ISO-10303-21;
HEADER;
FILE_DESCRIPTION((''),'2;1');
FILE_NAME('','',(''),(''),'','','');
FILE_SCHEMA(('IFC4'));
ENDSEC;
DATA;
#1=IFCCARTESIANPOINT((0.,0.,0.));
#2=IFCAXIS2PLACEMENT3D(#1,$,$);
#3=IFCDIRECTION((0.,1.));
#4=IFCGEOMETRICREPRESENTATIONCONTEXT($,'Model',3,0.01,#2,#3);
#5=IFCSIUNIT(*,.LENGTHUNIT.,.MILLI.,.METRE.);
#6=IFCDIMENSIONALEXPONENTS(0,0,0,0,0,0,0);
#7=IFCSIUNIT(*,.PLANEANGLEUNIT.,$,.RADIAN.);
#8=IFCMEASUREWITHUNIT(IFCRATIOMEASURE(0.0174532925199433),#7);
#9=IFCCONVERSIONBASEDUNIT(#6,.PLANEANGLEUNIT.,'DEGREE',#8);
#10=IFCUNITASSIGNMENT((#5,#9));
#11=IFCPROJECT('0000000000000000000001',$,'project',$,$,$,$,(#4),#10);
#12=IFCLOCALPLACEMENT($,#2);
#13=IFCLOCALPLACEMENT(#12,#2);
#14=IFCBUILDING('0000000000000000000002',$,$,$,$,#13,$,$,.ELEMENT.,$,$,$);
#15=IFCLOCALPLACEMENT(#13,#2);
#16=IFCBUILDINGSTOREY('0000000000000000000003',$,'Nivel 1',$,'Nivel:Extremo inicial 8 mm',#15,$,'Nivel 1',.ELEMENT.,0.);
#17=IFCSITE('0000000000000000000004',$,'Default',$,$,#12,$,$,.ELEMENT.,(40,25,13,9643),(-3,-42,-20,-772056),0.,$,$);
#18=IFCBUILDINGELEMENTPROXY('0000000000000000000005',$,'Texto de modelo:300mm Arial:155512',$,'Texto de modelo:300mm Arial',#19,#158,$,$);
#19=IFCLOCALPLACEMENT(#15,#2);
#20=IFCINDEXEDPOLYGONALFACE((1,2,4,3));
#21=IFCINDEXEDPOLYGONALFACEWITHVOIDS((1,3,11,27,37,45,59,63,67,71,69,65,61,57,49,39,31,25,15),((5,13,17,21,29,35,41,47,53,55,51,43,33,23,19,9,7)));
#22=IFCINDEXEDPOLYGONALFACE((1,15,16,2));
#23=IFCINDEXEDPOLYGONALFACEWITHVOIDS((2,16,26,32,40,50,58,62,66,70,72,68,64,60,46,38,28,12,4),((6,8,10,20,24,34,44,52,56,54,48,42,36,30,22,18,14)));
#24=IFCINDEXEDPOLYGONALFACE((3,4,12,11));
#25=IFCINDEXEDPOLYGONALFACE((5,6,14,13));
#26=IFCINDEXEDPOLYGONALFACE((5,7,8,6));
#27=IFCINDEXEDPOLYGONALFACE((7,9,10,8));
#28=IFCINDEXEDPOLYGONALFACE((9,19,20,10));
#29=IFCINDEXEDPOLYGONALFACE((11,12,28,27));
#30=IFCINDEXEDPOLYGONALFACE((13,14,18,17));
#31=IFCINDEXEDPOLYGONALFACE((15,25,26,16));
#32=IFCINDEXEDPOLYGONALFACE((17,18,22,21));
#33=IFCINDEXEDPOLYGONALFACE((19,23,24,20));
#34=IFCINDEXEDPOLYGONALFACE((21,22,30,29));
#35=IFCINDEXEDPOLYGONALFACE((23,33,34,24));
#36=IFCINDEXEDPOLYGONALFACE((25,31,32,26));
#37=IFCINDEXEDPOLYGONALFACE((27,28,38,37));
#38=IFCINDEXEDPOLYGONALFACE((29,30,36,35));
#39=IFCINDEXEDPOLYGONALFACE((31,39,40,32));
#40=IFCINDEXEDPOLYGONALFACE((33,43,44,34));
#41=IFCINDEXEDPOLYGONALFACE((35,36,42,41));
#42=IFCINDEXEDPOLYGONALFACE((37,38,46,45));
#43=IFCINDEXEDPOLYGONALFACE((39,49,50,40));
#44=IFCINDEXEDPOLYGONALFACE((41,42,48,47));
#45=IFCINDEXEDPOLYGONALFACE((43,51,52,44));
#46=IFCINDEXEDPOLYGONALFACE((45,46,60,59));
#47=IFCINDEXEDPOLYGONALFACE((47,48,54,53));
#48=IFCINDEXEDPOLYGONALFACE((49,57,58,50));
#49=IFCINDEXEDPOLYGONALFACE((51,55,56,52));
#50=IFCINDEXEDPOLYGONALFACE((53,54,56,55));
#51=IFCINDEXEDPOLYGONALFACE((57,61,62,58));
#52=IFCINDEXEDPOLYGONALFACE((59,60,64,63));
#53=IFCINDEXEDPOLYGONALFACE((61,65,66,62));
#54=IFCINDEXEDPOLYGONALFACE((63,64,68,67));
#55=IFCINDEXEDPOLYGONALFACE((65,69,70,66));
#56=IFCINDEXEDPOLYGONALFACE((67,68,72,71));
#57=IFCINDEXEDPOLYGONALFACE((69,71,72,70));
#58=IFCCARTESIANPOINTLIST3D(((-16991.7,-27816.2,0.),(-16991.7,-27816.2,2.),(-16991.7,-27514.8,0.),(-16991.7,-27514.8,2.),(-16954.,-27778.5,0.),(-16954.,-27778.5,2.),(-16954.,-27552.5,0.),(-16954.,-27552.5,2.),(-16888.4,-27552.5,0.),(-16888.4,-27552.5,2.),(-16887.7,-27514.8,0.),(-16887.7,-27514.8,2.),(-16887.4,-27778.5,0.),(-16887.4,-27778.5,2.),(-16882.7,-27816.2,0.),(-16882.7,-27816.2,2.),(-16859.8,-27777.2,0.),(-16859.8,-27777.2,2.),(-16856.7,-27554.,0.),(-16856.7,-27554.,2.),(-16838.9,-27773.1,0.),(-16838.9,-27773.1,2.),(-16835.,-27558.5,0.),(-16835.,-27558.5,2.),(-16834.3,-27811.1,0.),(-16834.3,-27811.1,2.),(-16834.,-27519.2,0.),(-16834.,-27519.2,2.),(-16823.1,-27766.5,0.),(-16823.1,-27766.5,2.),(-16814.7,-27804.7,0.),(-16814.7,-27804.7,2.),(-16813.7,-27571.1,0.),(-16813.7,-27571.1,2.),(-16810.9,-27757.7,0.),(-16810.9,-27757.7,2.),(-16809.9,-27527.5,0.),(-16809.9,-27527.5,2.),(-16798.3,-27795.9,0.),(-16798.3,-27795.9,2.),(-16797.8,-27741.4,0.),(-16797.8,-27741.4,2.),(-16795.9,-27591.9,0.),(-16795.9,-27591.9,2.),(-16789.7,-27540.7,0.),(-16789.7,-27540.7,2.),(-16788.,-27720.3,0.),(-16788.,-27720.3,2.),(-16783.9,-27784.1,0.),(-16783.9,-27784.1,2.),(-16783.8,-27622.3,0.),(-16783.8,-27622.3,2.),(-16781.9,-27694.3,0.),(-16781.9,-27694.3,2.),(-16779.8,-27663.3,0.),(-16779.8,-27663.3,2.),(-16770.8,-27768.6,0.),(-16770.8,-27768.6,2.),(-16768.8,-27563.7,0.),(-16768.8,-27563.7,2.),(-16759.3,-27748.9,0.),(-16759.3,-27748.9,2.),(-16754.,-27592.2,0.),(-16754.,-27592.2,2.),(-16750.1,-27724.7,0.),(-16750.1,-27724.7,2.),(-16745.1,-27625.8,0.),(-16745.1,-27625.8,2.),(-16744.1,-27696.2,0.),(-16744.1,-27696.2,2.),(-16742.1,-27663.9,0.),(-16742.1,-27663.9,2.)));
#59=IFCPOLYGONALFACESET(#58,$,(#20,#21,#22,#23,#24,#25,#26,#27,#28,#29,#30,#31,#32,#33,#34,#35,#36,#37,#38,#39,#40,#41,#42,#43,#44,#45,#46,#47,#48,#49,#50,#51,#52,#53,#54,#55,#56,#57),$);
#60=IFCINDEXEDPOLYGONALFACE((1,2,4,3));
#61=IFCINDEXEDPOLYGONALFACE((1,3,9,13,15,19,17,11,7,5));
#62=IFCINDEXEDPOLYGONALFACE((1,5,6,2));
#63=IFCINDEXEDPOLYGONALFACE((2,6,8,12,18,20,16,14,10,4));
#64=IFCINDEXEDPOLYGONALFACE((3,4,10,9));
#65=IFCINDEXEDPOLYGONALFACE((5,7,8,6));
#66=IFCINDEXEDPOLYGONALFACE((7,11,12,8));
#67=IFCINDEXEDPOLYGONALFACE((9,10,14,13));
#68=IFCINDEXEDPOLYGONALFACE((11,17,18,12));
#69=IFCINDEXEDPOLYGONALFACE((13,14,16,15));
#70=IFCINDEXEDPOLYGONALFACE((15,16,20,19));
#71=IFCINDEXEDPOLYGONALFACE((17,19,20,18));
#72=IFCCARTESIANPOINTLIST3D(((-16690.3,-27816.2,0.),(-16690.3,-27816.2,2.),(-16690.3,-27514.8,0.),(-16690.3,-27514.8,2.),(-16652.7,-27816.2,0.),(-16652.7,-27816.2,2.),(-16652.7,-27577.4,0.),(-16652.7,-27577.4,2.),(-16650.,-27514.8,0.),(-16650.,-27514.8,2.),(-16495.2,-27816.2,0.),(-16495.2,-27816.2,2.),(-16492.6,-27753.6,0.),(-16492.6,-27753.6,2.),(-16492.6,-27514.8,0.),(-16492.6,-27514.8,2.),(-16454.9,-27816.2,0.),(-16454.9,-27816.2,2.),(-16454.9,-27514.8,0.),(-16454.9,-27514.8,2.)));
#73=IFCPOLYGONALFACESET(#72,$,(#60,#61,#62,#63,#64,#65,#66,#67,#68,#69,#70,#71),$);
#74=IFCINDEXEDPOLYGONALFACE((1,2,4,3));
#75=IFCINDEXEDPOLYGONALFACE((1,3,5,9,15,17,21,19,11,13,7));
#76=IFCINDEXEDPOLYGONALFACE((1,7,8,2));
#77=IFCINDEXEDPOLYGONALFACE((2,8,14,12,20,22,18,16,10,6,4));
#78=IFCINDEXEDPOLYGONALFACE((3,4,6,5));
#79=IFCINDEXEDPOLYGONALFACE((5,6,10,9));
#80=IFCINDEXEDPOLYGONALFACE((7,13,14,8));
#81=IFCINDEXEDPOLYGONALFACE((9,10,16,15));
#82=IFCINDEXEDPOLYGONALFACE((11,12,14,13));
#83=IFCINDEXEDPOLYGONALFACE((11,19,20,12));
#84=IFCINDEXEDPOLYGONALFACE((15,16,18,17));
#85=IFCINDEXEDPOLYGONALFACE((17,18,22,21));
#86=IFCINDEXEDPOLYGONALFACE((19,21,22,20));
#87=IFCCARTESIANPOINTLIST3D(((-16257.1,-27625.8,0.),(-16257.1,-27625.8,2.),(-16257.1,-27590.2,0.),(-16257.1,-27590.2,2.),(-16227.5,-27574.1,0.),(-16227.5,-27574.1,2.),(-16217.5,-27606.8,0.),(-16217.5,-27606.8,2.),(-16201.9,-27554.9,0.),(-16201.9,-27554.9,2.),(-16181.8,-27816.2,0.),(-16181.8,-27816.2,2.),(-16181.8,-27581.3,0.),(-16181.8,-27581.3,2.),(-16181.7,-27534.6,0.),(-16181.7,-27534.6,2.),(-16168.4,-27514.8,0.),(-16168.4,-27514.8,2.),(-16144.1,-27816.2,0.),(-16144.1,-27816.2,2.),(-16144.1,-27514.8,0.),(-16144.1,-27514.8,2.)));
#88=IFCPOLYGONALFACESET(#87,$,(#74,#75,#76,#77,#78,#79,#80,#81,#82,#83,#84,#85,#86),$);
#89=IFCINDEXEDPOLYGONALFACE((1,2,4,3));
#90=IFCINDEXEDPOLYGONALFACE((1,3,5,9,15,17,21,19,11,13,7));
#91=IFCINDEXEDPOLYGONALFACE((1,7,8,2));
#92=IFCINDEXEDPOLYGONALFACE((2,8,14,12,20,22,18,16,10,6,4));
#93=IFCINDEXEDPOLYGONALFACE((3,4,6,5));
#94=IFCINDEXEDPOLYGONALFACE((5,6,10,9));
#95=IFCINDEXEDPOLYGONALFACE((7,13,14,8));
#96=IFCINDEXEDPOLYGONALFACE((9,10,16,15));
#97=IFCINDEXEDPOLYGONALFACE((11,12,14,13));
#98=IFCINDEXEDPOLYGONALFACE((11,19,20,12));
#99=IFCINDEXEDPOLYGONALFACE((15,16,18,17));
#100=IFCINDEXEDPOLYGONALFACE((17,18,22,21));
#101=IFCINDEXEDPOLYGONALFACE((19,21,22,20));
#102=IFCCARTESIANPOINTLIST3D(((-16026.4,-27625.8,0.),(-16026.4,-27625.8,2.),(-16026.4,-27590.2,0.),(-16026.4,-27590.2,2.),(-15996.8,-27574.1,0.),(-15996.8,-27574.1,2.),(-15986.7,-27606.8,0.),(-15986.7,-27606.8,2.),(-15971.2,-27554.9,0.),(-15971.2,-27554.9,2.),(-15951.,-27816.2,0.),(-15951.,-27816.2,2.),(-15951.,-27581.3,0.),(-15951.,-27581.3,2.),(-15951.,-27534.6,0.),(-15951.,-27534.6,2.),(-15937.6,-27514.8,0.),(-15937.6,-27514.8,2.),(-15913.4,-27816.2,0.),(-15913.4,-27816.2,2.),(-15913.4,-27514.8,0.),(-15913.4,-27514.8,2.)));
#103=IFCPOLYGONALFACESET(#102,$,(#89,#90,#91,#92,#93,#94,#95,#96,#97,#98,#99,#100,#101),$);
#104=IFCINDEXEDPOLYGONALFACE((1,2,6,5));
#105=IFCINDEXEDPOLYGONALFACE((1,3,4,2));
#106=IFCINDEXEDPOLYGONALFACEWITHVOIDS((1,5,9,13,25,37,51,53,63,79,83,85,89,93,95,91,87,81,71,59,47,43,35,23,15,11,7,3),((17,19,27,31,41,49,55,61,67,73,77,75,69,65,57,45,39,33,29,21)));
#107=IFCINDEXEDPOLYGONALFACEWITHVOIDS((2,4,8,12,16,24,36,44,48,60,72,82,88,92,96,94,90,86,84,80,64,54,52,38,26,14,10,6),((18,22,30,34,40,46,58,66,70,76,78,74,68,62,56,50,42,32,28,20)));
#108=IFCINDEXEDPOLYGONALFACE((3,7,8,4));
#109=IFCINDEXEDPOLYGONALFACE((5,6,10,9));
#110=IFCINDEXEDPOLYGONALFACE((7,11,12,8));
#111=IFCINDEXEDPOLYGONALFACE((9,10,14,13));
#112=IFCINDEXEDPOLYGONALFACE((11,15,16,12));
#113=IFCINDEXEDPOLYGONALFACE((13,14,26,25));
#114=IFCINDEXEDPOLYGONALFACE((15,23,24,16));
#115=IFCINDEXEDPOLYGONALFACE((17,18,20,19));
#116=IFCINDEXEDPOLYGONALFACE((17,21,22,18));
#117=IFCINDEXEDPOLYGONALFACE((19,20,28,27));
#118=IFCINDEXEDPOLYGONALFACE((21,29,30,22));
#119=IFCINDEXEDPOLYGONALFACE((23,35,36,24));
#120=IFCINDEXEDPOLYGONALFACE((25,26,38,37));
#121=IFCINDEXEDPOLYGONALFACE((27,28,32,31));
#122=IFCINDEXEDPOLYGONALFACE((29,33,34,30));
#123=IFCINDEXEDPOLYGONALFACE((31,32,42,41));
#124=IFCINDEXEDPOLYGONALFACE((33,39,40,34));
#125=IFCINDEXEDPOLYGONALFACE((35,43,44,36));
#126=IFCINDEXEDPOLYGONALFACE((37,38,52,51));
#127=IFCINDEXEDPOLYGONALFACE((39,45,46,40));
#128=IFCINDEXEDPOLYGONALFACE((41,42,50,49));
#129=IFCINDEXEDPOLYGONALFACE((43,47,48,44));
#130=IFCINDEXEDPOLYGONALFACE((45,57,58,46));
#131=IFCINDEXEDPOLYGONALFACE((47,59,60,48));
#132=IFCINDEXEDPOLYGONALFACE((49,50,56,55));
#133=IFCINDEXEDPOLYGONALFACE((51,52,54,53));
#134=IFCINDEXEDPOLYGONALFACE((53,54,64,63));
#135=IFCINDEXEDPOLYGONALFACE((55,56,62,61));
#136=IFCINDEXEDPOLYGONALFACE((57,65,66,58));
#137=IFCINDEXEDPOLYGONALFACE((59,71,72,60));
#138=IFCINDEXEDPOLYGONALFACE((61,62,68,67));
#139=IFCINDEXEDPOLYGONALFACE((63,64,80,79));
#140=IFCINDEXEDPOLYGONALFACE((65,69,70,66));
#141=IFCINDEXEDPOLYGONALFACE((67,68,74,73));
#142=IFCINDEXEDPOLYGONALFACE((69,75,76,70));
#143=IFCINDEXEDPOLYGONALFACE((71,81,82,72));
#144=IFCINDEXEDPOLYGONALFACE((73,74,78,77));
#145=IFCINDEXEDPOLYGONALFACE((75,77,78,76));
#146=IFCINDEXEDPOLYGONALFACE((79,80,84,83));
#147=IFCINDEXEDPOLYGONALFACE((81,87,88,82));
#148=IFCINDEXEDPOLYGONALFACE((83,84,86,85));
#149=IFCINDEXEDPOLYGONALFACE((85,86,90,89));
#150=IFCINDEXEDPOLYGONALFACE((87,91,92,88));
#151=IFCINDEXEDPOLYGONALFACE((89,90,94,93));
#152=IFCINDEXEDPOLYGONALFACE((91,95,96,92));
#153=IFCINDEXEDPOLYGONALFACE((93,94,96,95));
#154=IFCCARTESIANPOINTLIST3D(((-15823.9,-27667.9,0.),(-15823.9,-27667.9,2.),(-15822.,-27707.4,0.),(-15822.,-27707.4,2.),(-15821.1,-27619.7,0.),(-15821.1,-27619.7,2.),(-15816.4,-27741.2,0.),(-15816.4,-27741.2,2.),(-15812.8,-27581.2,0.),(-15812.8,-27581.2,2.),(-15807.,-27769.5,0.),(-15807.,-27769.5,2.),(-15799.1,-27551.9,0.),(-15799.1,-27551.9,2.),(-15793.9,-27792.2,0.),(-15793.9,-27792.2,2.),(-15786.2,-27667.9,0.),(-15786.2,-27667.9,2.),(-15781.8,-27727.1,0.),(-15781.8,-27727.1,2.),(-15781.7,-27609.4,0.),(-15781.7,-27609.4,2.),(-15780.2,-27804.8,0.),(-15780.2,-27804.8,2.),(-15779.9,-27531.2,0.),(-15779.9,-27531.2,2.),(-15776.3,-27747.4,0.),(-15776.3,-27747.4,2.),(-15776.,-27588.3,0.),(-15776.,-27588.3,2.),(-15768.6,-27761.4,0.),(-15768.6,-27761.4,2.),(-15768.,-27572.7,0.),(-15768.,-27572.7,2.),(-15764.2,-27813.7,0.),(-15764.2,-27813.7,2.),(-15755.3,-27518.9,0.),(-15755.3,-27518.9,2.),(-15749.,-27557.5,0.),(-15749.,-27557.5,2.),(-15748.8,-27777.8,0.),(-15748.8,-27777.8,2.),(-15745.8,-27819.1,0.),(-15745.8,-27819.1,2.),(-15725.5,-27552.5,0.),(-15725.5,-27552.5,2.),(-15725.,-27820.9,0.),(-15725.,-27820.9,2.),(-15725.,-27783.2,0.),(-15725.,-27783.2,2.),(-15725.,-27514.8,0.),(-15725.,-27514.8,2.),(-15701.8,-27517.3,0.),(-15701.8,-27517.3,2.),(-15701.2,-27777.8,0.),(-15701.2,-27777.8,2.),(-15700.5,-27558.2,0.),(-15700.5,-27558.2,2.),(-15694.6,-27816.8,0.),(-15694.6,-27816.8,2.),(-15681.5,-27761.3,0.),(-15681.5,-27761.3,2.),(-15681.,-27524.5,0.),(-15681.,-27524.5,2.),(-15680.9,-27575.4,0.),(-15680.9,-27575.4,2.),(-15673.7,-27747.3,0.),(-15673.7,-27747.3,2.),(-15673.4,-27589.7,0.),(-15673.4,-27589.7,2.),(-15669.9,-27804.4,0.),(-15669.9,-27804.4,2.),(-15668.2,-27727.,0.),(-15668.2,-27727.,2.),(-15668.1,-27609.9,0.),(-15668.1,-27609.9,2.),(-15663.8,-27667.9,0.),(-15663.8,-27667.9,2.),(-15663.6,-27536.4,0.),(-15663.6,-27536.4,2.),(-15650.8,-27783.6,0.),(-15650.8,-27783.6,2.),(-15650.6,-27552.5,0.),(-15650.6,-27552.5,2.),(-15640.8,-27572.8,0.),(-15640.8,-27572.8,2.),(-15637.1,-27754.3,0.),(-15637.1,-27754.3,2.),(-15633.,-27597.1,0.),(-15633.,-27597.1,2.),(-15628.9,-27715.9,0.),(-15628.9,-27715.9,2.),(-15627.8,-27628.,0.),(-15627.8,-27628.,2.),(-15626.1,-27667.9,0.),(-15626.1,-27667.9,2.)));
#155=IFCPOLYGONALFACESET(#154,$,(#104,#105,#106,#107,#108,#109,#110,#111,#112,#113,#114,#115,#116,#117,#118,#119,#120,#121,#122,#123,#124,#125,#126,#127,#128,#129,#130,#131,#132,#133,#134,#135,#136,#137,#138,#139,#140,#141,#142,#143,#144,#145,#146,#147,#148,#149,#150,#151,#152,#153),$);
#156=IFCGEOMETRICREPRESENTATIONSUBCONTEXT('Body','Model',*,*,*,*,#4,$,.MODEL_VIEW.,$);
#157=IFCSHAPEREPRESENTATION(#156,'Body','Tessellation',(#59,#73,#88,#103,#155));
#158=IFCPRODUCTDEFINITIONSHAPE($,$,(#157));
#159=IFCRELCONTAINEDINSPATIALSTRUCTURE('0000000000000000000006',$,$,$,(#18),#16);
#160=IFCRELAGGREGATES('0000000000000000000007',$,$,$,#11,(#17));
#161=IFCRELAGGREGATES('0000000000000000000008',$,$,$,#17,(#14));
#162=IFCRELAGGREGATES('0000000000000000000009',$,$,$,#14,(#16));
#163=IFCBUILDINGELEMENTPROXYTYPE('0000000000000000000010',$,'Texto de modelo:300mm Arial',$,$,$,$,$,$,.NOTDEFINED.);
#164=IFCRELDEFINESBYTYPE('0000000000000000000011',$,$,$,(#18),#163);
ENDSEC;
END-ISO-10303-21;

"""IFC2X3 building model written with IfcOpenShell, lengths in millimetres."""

from ifc_helpers import new_model, entity, si_unit, converted_unit, direction, frame, origin, place, context, subcontext, project, spatial, polyline, outline, extrude, type_object, element, save


model = new_model("IFC2X3")

# Units and contexts
model_context = context("Model", 3, precision=0.01, world=origin(), true_north=direction((0.0, 1.0)))
body_context = subcontext(model_context, "Body", "Model", "MODEL_VIEW")
ifc_project = project(units=[si_unit("LENGTHUNIT", "METRE", prefix="MILLI"), converted_unit("PLANEANGLEUNIT", "DEGREE", entity("IfcRatioMeasure", 0.0174532925199433), si_unit("PLANEANGLEUNIT", "RADIAN"), dimensions=[0, 0, 0, 0, 0, 0, 0])], contexts=[model_context])

# Site, building, storey
site_placement = place(None, origin())
site = spatial("IfcSite", under=ifc_project, at=site_placement, Name="Default", CompositionType="ELEMENT", RefLatitude=(40, 25, 13, 9643), RefLongitude=(-3, -42, -20, -772056), RefElevation=0.0)
building_placement = place(site_placement, origin())
building = spatial("IfcBuilding", under=site, at=building_placement, CompositionType="ELEMENT")
storey_placement = place(building_placement, origin())
storey = spatial("IfcBuildingStorey", under=building, at=storey_placement, Name="Nivel 1", ObjectType="Nivel:Extremo inicial 8 mm", LongName="Nivel 1", CompositionType="ELEMENT", Elevation=0.0)

# Building element proxy
building_element_proxy_type_1 = type_object("IfcBuildingElementProxyType", Name="Texto de modelo:300mm Arial", PredefinedType="NOTDEFINED")
proxy_1_placement = place(storey_placement, frame((-16991.7, -27820.9, 0.0)))
element("IfcBuildingElementProxy", 1, at=proxy_1_placement, inside=storey, type_object=building_element_proxy_type_1, Name="Texto de modelo:300mm Arial:155512", ObjectType="Texto de modelo:300mm Arial", context=body_context, shape_type="SweptSolid", body=[
    extrude(outline(polyline([(-178.4, -141.0), (-69.4, -141.0), (-21.0, -135.8), (-1.4, -129.5), (15.0, -120.7), (29.4, -108.9), (42.6, -93.4), (54.0, -73.7), (63.2, -49.5), (69.2, -21.0), (71.2, 11.3), (68.2, 49.4), (59.3, 83.0), (44.5, 111.5), (23.7, 134.5), (3.4, 147.7), (-20.6, 156.1), (-74.4, 160.4), (-178.4, 160.4), (-178.4, -141.0)]), holes=[polyline([(-140.7, -103.3), (-140.7, 122.7), (-75.1, 122.7), (-43.3, 121.2), (-21.7, 116.7), (-0.4, 104.1), (17.4, 83.3), (29.5, 53.0), (33.5, 11.9), (31.5, -19.1), (25.3, -45.1), (15.5, -66.2), (2.4, -82.5), (-9.8, -91.3), (-25.6, -97.9), (-46.5, -101.9), (-74.1, -103.3), (-140.7, -103.3)])]), frame((178.4, 145.7, 0.0)), (0.0, 0.0, 1.0), 2.0),
    extrude(outline(polyline([(-117.7, -150.7), (-80.1, -150.7), (-80.1, 88.1), (77.4, -150.7), (117.7, -150.7), (117.7, 150.7), (80.1, 150.7), (80.1, -88.1), (-77.4, 150.7), (-117.7, 150.7), (-117.7, -150.7)])), frame((419.1, 155.4, 0.0)), (0.0, 0.0, 1.0), 2.0),
    extrude(outline(polyline([(-204.4, -52.5), (97.0, -52.5), (97.0, -28.2), (77.2, -14.9), (56.9, 5.3), (37.7, 30.9), (21.6, 60.5), (-14.0, 60.5), (5.0, 20.8), (30.4, -14.9), (-204.4, -14.9), (-204.4, -52.5)])), frame((795.1, 209.1, 0.0), z_axis=(0.0, 0.0, 1.0), x_axis=(0.0, 1.0, 0.0)), (0.0, 0.0, 1.0), 2.0),
    extrude(outline(polyline([(-204.4, -52.5), (97.0, -52.5), (97.0, -28.2), (77.2, -14.9), (56.9, 5.3), (37.7, 30.9), (21.6, 60.5), (-14.0, 60.5), (5.0, 20.8), (30.4, -14.9), (-204.4, -14.9), (-204.4, -52.5)])), frame((1025.8, 209.1, 0.0), z_axis=(0.0, 0.0, 1.0), x_axis=(0.0, 1.0, 0.0)), (0.0, 0.0, 1.0), 2.0),
    extrude(outline(polyline([(-5.6, -99.5), (33.9, -99.5), (68.0, -95.5), (96.7, -87.5), (120.0, -75.5), (133.2, -62.4), (142.9, -46.8), (149.1, -28.7), (151.9, -8.0), (149.2, 22.6), (138.0, 47.8), (118.2, 67.9), (89.5, 82.9), (51.6, 93.0), (3.8, 98.0), (-36.2, 98.2), (-67.3, 94.5), (-91.9, 87.9), (-112.6, 79.0), (-129.4, 66.8), (-142.0, 50.0), (-150.3, 29.6), (-153.8, 6.5), (-151.2, -23.9), (-140.1, -49.1), (-120.3, -69.2), (-91.7, -84.4), (-53.6, -94.5), (-5.6, -99.5)]), holes=[polyline([(-3.9, -61.9), (-62.1, -54.6), (-82.9, -47.9), (-98.1, -39.2), (-112.3, -19.5), (-116.2, 4.3), (-109.3, 28.9), (-91.2, 47.7), (-76.5, 54.5), (-56.1, 58.9), (1.9, 60.4), (60.8, 53.2), (80.8, 46.7), (94.5, 38.3), (109.9, 17.8), (114.3, -6.3), (107.7, -29.8), (90.4, -48.7), (76.0, -55.8), (55.5, -60.3), (-3.9, -61.9)])]), frame((1267.5, 152.1, 0.0), z_axis=(0.0, 0.0, 1.0), x_axis=(0.047515, -0.998871, 0.0)), (0.0, 0.0, 1.0), 2.0),
])

save(model, "model.ifc")
